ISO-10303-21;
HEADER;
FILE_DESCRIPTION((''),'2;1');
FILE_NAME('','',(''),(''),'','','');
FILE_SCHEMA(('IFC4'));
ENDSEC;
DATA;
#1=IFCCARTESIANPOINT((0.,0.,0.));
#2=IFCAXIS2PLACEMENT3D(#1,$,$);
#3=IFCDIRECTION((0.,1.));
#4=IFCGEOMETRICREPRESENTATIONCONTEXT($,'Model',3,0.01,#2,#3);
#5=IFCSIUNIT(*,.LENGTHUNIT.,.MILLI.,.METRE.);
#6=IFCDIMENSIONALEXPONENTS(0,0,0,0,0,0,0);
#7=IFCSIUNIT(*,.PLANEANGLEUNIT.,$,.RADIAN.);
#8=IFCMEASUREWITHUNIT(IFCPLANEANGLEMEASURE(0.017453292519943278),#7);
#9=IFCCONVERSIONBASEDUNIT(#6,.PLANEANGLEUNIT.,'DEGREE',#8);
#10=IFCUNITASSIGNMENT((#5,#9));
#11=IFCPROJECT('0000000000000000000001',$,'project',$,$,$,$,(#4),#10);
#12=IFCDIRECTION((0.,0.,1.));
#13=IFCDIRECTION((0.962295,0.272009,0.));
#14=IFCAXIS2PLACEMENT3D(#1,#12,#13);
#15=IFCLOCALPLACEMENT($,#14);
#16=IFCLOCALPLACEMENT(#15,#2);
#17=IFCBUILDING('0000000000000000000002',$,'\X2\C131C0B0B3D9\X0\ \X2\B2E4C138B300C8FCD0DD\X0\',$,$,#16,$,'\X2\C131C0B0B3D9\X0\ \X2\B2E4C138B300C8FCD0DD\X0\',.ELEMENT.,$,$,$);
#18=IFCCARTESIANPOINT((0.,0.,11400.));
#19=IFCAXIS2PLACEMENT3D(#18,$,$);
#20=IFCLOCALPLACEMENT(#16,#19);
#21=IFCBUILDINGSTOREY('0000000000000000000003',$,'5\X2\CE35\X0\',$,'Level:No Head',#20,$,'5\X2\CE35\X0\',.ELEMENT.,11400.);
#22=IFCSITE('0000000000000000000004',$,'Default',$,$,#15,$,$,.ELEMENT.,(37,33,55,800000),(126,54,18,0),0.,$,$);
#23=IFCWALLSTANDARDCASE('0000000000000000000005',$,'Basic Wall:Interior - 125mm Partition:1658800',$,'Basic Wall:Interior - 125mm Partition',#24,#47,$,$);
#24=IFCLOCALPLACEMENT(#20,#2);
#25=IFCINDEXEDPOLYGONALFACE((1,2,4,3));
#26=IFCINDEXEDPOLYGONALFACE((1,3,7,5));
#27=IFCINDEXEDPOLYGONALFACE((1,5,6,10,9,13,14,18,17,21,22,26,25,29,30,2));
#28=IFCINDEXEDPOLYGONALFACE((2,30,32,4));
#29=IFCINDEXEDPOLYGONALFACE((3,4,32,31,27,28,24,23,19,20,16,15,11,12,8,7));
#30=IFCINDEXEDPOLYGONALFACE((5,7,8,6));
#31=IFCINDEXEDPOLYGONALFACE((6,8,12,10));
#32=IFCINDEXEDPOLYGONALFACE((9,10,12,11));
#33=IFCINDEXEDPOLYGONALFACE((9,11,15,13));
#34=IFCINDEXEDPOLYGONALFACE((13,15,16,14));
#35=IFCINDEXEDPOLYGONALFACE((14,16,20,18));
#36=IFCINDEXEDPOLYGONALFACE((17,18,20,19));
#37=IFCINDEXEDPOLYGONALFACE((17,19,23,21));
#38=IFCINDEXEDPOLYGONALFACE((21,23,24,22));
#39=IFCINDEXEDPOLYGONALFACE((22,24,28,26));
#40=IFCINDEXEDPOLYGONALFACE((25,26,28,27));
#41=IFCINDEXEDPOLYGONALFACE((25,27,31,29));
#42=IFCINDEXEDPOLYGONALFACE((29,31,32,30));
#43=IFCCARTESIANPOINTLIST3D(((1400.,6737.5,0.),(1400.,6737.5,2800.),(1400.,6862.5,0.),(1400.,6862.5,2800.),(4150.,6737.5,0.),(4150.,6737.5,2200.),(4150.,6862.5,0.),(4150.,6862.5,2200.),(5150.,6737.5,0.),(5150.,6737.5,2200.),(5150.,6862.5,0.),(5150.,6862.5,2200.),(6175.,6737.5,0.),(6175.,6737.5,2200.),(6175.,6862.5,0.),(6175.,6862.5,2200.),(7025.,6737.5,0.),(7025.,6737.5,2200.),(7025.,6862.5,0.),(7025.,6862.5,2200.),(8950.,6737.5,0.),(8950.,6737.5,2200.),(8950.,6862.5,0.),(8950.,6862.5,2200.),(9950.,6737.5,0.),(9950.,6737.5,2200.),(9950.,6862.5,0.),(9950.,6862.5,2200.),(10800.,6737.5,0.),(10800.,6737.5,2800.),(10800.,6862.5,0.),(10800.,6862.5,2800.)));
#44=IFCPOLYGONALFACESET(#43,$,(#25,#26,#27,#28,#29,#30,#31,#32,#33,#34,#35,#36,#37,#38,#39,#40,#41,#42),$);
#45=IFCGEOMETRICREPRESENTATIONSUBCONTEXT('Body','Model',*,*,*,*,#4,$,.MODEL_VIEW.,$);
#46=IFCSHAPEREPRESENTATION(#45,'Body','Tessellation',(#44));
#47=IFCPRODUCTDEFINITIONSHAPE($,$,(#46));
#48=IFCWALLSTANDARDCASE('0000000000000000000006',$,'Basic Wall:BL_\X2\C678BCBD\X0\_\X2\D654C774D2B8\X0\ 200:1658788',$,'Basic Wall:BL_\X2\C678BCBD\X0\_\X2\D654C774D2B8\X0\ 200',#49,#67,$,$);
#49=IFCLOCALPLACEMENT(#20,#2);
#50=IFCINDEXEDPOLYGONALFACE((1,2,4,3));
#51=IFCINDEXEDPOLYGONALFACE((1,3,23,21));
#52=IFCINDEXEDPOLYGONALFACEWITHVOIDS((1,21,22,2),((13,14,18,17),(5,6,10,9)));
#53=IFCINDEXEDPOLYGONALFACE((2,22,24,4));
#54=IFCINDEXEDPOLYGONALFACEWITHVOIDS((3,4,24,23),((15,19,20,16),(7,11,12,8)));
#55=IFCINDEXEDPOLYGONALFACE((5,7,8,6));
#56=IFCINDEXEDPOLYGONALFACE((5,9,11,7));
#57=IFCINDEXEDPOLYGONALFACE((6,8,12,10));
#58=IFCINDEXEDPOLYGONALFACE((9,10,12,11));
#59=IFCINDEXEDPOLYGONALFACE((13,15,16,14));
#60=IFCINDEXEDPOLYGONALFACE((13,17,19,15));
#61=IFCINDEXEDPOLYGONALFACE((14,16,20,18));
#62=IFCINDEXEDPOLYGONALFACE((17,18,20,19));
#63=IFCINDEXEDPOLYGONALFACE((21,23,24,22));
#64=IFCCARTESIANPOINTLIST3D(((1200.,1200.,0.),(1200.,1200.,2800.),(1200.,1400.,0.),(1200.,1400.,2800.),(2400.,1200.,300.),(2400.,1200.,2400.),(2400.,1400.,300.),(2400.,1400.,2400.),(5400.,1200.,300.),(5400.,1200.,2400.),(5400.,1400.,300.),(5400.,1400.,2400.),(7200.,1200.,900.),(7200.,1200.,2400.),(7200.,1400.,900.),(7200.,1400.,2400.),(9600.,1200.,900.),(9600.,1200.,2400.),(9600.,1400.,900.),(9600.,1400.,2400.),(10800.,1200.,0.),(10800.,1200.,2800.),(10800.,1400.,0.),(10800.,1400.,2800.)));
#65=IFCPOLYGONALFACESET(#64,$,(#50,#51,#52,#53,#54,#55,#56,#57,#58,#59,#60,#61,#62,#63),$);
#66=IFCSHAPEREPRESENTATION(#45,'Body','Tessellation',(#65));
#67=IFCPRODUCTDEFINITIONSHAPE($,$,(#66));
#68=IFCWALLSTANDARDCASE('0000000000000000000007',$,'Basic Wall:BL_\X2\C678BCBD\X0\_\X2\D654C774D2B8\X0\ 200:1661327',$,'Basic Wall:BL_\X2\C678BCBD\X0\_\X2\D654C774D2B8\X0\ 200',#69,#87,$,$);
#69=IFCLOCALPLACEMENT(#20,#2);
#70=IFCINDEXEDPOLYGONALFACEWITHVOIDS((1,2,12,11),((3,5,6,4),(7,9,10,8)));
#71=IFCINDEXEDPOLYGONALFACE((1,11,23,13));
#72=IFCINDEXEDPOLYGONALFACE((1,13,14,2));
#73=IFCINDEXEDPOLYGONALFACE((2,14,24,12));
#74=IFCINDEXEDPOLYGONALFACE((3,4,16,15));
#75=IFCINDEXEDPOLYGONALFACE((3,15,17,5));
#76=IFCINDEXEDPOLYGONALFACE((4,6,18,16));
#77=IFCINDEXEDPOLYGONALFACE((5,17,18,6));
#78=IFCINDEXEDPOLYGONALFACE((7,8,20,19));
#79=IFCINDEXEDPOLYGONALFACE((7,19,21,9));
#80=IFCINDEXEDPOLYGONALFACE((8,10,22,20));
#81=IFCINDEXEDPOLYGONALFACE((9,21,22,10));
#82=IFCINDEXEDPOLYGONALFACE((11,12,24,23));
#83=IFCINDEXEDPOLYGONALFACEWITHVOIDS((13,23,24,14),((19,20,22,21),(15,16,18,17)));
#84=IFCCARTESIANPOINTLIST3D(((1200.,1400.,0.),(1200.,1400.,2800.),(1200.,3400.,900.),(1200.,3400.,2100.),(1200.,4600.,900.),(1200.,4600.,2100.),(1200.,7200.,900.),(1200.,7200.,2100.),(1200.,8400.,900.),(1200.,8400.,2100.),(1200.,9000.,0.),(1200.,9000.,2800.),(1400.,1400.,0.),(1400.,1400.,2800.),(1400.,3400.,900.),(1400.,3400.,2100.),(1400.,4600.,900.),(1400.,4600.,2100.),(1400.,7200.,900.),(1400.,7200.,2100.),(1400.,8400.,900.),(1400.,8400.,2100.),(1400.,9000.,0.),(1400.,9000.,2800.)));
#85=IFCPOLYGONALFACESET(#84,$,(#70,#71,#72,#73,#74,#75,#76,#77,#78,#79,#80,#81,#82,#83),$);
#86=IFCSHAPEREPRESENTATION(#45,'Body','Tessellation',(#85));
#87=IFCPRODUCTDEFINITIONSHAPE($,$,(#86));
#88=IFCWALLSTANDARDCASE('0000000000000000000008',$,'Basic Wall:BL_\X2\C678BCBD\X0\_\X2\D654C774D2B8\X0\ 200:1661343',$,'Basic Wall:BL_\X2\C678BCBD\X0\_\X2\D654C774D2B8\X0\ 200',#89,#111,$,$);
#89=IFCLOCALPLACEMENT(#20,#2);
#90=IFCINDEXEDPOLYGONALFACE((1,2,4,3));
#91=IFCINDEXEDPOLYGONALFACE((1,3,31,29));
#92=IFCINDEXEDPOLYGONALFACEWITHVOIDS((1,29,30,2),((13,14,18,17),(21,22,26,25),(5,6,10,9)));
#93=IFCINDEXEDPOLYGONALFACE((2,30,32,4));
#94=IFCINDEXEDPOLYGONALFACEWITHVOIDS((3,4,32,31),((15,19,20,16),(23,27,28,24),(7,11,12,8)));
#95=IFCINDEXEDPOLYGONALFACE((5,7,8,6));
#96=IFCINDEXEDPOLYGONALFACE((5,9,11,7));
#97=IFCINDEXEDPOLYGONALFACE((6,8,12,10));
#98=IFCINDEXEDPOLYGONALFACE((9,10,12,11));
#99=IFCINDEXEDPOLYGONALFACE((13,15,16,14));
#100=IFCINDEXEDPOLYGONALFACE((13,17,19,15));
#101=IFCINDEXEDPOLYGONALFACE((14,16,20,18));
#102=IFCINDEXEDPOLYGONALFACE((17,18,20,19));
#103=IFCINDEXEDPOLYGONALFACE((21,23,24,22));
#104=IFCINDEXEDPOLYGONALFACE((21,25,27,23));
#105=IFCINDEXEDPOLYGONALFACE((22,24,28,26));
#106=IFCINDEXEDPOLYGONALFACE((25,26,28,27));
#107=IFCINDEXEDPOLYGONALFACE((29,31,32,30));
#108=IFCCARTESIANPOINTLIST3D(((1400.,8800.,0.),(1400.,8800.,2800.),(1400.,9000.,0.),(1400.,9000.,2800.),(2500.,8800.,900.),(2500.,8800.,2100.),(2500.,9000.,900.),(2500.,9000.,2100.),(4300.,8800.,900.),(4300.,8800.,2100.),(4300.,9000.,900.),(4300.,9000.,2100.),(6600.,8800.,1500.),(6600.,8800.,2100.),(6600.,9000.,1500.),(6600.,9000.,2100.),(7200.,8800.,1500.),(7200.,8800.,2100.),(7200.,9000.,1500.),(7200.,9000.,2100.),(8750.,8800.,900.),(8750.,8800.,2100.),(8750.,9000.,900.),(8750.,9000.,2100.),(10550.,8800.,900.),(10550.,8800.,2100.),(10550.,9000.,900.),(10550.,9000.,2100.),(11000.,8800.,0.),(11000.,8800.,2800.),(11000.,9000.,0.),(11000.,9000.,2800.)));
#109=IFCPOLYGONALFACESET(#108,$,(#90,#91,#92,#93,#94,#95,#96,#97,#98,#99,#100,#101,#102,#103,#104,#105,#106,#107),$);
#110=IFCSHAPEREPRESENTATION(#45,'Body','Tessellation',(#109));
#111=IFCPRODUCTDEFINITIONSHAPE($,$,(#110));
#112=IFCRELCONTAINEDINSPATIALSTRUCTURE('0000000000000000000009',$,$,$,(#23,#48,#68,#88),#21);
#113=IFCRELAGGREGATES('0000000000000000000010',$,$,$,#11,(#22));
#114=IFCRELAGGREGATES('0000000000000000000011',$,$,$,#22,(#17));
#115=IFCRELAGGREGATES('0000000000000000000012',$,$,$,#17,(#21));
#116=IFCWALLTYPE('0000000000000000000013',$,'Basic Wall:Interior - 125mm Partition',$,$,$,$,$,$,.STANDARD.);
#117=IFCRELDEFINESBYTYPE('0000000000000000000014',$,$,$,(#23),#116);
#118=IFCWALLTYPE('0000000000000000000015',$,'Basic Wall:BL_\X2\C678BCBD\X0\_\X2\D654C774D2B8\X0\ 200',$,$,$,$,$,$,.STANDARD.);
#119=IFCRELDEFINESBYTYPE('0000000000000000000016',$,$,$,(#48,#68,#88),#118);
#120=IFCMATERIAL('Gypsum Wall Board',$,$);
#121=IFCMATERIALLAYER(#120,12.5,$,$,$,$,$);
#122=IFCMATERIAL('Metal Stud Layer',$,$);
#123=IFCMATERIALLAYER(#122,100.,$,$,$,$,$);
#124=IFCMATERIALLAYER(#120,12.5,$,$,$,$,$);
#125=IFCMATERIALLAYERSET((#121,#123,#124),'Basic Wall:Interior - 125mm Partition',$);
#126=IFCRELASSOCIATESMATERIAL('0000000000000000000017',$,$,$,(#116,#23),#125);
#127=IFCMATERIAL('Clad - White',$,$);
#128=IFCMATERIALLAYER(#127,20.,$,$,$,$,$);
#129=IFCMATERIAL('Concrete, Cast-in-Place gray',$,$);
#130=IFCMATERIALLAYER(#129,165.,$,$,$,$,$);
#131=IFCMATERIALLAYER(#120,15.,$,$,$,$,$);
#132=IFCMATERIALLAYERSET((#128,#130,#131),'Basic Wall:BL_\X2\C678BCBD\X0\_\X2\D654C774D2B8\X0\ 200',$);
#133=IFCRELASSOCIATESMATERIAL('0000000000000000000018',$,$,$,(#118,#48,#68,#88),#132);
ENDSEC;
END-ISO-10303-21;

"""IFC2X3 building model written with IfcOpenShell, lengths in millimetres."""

from ifc_helpers import new_model, entity, si_unit, converted_unit, direction, frame, frame_2d, origin, place, context, subcontext, project, spatial, rectangle, extrude, material, layer, layer_set, layer_usage, type_object, element, save


model = new_model("IFC2X3")

# Units and contexts
model_context = context("Model", 3, precision=0.01, world=origin(), true_north=direction((0.0, 1.0)))
body_context = subcontext(model_context, "Body", "Model", "MODEL_VIEW")
ifc_project = project(units=[si_unit("LENGTHUNIT", "METRE", prefix="MILLI"), converted_unit("PLANEANGLEUNIT", "DEGREE", entity("IfcPlaneAngleMeasure", 0.017453292519943278), si_unit("PLANEANGLEUNIT", "RADIAN"), dimensions=[0, 0, 0, 0, 0, 0, 0])], contexts=[model_context])

# Site, building, storey
site_placement = place(None, frame((0.0, 0.0, 0.0), z_axis=(0.0, 0.0, 1.0), x_axis=(0.962295, 0.272009, 0.0)))
site = spatial("IfcSite", under=ifc_project, at=site_placement, Name="Default", CompositionType="ELEMENT", RefLatitude=(37, 33, 55, 800000), RefLongitude=(126, 54, 18, 0), RefElevation=0.0)
building_placement = place(site_placement, origin())
building = spatial("IfcBuilding", under=site, at=building_placement, Name="성산동 다세대주택", LongName="성산동 다세대주택", CompositionType="ELEMENT")
storey_placement = place(building_placement, frame((0.0, 0.0, 11400.0)))
storey = spatial("IfcBuildingStorey", under=building, at=storey_placement, Name="5층", ObjectType="Level:No Head", LongName="5층", CompositionType="ELEMENT", Elevation=11400.0)

# Walls, openings
ifc_material_1 = material(Name="Gypsum Wall Board")
ifc_layer_1 = layer(ifc_material_1, 12.5)
ifc_material_2 = material(Name="Metal Stud Layer")
ifc_layer_2 = layer(ifc_material_2, 100.0)
ifc_layer_3 = layer(ifc_material_1, 12.5)
ifc_layer_set_1 = layer_set([ifc_layer_1, ifc_layer_2, ifc_layer_3], Name="Basic Wall:Interior - 125mm Partition")
ifc_layer_usage_1 = layer_usage(ifc_layer_set_1, "AXIS2", "NEGATIVE", 62.5)
wall_type_1 = type_object("IfcWallType", Name="Basic Wall:Interior - 125mm Partition", PredefinedType="STANDARD", material=ifc_layer_set_1)
wall_1_placement = place(storey_placement, frame((1400.0, 6800.0, 0.0)))
wall_1 = element("IfcWallStandardCase", 1, at=wall_1_placement, inside=storey, type_object=wall_type_1, material=ifc_layer_usage_1, Name="Basic Wall:Interior - 125mm Partition:1658800", ObjectType="Basic Wall:Interior - 125mm Partition", context=body_context, shape_type="SweptSolid", body=[
    extrude(rectangle(XDim=9400.0, YDim=125.0, at=frame_2d((4700.0, 0.0), x_axis=(1.0, 0.0))), origin(), (0.0, 0.0, 1.0), 2800.0),
])
opening_1_placement = place(wall_1_placement, frame((7550.0, -62.5, 0.0)))
element("IfcOpeningElement", 2, at=opening_1_placement, cuts=wall_1, ObjectType="Opening", context=body_context, shape_type="SweptSolid", body=[
    extrude(rectangle(XDim=2200.0, YDim=1000.0, at=frame_2d((1100.0, 500.0), x_axis=(1.0, 0.0))), frame((0.0, 0.0, 0.0), z_axis=(0.0, 1.0, 0.0), x_axis=(0.0, 0.0, 1.0)), (0.0, 0.0, 1.0), 125.0),
])
opening_2_placement = place(wall_1_placement, frame((4775.0, -62.5, 0.0)))
element("IfcOpeningElement", 3, at=opening_2_placement, cuts=wall_1, ObjectType="Opening", context=body_context, shape_type="SweptSolid", body=[
    extrude(rectangle(XDim=2200.0, YDim=850.0, at=frame_2d((1100.0, 425.0), x_axis=(1.0, 0.0))), frame((0.0, 0.0, 0.0), z_axis=(0.0, 1.0, 0.0), x_axis=(0.0, 0.0, 1.0)), (0.0, 0.0, 1.0), 125.0),
])
opening_3_placement = place(wall_1_placement, frame((2750.0, -62.5, 0.0)))
element("IfcOpeningElement", 4, at=opening_3_placement, cuts=wall_1, ObjectType="Opening", context=body_context, shape_type="SweptSolid", body=[
    extrude(rectangle(XDim=2200.0, YDim=1000.0, at=frame_2d((1100.0, 500.0), x_axis=(1.0, 0.0))), frame((0.0, 0.0, 0.0), z_axis=(0.0, 1.0, 0.0), x_axis=(0.0, 0.0, 1.0)), (0.0, 0.0, 1.0), 125.0),
])
ifc_material_3 = material(Name="Clad - White")
ifc_layer_4 = layer(ifc_material_3, 20.0)
ifc_material_4 = material(Name="Concrete, Cast-in-Place gray")
ifc_layer_5 = layer(ifc_material_4, 165.0)
ifc_layer_6 = layer(ifc_material_1, 15.0)
ifc_layer_set_2 = layer_set([ifc_layer_4, ifc_layer_5, ifc_layer_6], Name="Basic Wall:BL_외벽_화이트 200")
ifc_layer_usage_2 = layer_usage(ifc_layer_set_2, "AXIS2", "POSITIVE", -100.0)
wall_type_2 = type_object("IfcWallType", Name="Basic Wall:BL_외벽_화이트 200", PredefinedType="STANDARD", material=ifc_layer_set_2)
wall_2_placement = place(storey_placement, frame((1200.0, 1300.0, 0.0)))
wall_2 = element("IfcWallStandardCase", 5, at=wall_2_placement, inside=storey, type_object=wall_type_2, material=ifc_layer_usage_2, Name="Basic Wall:BL_외벽_화이트 200:1658788", ObjectType="Basic Wall:BL_외벽_화이트 200", context=body_context, shape_type="SweptSolid", body=[
    extrude(rectangle(XDim=9600.0, YDim=200.0, at=frame_2d((4800.0, 0.0), x_axis=(-1.0, 0.0))), origin(), (0.0, 0.0, 1.0), 2800.0),
])
opening_4_placement = place(wall_2_placement, frame((1200.0, -100.0, 300.0)))
element("IfcOpeningElement", 6, at=opening_4_placement, cuts=wall_2, ObjectType="Opening", context=body_context, shape_type="SweptSolid", body=[
    extrude(rectangle(XDim=2100.0, YDim=3000.0, at=frame_2d((1050.0, 1500.0), x_axis=(-1.0, 0.0))), frame((0.0, 0.0, 0.0), z_axis=(0.0, 1.0, 0.0), x_axis=(0.0, 0.0, 1.0)), (0.0, 0.0, 1.0), 200.0),
])
opening_5_placement = place(wall_2_placement, frame((6000.0, -100.0, 900.0)))
element("IfcOpeningElement", 7, at=opening_5_placement, cuts=wall_2, ObjectType="Opening", context=body_context, shape_type="SweptSolid", body=[
    extrude(rectangle(XDim=1500.0, YDim=2400.0, at=frame_2d((750.0, 1200.0), x_axis=(-1.0, 0.0))), frame((0.0, 0.0, 0.0), z_axis=(0.0, 1.0, 0.0), x_axis=(0.0, 0.0, 1.0)), (0.0, 0.0, 1.0), 200.0),
])
ifc_layer_usage_3 = layer_usage(ifc_layer_set_2, "AXIS2", "NEGATIVE", 100.0)
wall_3_placement = place(storey_placement, frame((1300.0, 1400.0, 0.0), z_axis=(0.0, 0.0, 1.0), x_axis=(0.0, 1.0, 0.0)))
wall_3 = element("IfcWallStandardCase", 8, at=wall_3_placement, inside=storey, type_object=wall_type_2, material=ifc_layer_usage_3, Name="Basic Wall:BL_외벽_화이트 200:1661327", ObjectType="Basic Wall:BL_외벽_화이트 200", context=body_context, shape_type="SweptSolid", body=[
    extrude(rectangle(XDim=7600.0, YDim=200.0, at=frame_2d((3800.0, 0.0), x_axis=(-1.0, 0.0))), origin(), (0.0, 0.0, 1.0), 2800.0),
])
opening_6_placement = place(wall_3_placement, frame((2000.0, -100.0, 900.0)))
element("IfcOpeningElement", 9, at=opening_6_placement, cuts=wall_3, ObjectType="Opening", context=body_context, shape_type="SweptSolid", body=[
    extrude(rectangle(XDim=1200.0, YDim=1200.0, at=frame_2d((600.0, 600.0), x_axis=(-1.0, 0.0))), frame((0.0, 0.0, 0.0), z_axis=(0.0, 1.0, 0.0), x_axis=(0.0, 0.0, 1.0)), (0.0, 0.0, 1.0), 200.0),
])
opening_7_placement = place(wall_3_placement, frame((5800.0, -100.0, 900.0)))
element("IfcOpeningElement", 10, at=opening_7_placement, cuts=wall_3, ObjectType="Opening", context=body_context, shape_type="SweptSolid", body=[
    extrude(rectangle(XDim=1200.0, YDim=1200.0, at=frame_2d((600.0, 600.0), x_axis=(-1.0, 0.0))), frame((0.0, 0.0, 0.0), z_axis=(0.0, 1.0, 0.0), x_axis=(0.0, 0.0, 1.0)), (0.0, 0.0, 1.0), 200.0),
])
ifc_layer_usage_4 = layer_usage(ifc_layer_set_2, "AXIS2", "NEGATIVE", 100.0)
wall_4_placement = place(storey_placement, frame((1400.0, 8900.0, 0.0)))
wall_4 = element("IfcWallStandardCase", 11, at=wall_4_placement, inside=storey, type_object=wall_type_2, material=ifc_layer_usage_4, Name="Basic Wall:BL_외벽_화이트 200:1661343", ObjectType="Basic Wall:BL_외벽_화이트 200", context=body_context, shape_type="SweptSolid", body=[
    extrude(rectangle(XDim=9600.0, YDim=200.0, at=frame_2d((4800.0, 0.0), x_axis=(-1.0, 0.0))), origin(), (0.0, 0.0, 1.0), 2800.0),
])
opening_8_placement = place(wall_4_placement, frame((1100.0, -100.0, 900.0)))
element("IfcOpeningElement", 12, at=opening_8_placement, cuts=wall_4, ObjectType="Opening", context=body_context, shape_type="SweptSolid", body=[
    extrude(rectangle(XDim=1200.0, YDim=1800.0, at=frame_2d((600.0, 900.0), x_axis=(-1.0, 0.0))), frame((0.0, 0.0, 0.0), z_axis=(0.0, 1.0, 0.0), x_axis=(0.0, 0.0, 1.0)), (0.0, 0.0, 1.0), 200.0),
])
opening_9_placement = place(wall_4_placement, frame((5200.0, -100.0, 1500.0)))
element("IfcOpeningElement", 13, at=opening_9_placement, cuts=wall_4, ObjectType="Opening", context=body_context, shape_type="SweptSolid", body=[
    extrude(rectangle(XDim=600.0, YDim=600.0, at=frame_2d((300.0, 300.0), x_axis=(-1.0, 0.0))), frame((0.0, 0.0, 0.0), z_axis=(0.0, 1.0, 0.0), x_axis=(0.0, 0.0, 1.0)), (0.0, 0.0, 1.0), 200.0),
])
opening_10_placement = place(wall_4_placement, frame((7350.0, -100.0, 900.0)))
element("IfcOpeningElement", 14, at=opening_10_placement, cuts=wall_4, ObjectType="Opening", context=body_context, shape_type="SweptSolid", body=[
    extrude(rectangle(XDim=1200.0, YDim=1800.0, at=frame_2d((600.0, 900.0), x_axis=(-1.0, 0.0))), frame((0.0, 0.0, 0.0), z_axis=(0.0, 1.0, 0.0), x_axis=(0.0, 0.0, 1.0)), (0.0, 0.0, 1.0), 200.0),
])

save(model, "model.ifc")
